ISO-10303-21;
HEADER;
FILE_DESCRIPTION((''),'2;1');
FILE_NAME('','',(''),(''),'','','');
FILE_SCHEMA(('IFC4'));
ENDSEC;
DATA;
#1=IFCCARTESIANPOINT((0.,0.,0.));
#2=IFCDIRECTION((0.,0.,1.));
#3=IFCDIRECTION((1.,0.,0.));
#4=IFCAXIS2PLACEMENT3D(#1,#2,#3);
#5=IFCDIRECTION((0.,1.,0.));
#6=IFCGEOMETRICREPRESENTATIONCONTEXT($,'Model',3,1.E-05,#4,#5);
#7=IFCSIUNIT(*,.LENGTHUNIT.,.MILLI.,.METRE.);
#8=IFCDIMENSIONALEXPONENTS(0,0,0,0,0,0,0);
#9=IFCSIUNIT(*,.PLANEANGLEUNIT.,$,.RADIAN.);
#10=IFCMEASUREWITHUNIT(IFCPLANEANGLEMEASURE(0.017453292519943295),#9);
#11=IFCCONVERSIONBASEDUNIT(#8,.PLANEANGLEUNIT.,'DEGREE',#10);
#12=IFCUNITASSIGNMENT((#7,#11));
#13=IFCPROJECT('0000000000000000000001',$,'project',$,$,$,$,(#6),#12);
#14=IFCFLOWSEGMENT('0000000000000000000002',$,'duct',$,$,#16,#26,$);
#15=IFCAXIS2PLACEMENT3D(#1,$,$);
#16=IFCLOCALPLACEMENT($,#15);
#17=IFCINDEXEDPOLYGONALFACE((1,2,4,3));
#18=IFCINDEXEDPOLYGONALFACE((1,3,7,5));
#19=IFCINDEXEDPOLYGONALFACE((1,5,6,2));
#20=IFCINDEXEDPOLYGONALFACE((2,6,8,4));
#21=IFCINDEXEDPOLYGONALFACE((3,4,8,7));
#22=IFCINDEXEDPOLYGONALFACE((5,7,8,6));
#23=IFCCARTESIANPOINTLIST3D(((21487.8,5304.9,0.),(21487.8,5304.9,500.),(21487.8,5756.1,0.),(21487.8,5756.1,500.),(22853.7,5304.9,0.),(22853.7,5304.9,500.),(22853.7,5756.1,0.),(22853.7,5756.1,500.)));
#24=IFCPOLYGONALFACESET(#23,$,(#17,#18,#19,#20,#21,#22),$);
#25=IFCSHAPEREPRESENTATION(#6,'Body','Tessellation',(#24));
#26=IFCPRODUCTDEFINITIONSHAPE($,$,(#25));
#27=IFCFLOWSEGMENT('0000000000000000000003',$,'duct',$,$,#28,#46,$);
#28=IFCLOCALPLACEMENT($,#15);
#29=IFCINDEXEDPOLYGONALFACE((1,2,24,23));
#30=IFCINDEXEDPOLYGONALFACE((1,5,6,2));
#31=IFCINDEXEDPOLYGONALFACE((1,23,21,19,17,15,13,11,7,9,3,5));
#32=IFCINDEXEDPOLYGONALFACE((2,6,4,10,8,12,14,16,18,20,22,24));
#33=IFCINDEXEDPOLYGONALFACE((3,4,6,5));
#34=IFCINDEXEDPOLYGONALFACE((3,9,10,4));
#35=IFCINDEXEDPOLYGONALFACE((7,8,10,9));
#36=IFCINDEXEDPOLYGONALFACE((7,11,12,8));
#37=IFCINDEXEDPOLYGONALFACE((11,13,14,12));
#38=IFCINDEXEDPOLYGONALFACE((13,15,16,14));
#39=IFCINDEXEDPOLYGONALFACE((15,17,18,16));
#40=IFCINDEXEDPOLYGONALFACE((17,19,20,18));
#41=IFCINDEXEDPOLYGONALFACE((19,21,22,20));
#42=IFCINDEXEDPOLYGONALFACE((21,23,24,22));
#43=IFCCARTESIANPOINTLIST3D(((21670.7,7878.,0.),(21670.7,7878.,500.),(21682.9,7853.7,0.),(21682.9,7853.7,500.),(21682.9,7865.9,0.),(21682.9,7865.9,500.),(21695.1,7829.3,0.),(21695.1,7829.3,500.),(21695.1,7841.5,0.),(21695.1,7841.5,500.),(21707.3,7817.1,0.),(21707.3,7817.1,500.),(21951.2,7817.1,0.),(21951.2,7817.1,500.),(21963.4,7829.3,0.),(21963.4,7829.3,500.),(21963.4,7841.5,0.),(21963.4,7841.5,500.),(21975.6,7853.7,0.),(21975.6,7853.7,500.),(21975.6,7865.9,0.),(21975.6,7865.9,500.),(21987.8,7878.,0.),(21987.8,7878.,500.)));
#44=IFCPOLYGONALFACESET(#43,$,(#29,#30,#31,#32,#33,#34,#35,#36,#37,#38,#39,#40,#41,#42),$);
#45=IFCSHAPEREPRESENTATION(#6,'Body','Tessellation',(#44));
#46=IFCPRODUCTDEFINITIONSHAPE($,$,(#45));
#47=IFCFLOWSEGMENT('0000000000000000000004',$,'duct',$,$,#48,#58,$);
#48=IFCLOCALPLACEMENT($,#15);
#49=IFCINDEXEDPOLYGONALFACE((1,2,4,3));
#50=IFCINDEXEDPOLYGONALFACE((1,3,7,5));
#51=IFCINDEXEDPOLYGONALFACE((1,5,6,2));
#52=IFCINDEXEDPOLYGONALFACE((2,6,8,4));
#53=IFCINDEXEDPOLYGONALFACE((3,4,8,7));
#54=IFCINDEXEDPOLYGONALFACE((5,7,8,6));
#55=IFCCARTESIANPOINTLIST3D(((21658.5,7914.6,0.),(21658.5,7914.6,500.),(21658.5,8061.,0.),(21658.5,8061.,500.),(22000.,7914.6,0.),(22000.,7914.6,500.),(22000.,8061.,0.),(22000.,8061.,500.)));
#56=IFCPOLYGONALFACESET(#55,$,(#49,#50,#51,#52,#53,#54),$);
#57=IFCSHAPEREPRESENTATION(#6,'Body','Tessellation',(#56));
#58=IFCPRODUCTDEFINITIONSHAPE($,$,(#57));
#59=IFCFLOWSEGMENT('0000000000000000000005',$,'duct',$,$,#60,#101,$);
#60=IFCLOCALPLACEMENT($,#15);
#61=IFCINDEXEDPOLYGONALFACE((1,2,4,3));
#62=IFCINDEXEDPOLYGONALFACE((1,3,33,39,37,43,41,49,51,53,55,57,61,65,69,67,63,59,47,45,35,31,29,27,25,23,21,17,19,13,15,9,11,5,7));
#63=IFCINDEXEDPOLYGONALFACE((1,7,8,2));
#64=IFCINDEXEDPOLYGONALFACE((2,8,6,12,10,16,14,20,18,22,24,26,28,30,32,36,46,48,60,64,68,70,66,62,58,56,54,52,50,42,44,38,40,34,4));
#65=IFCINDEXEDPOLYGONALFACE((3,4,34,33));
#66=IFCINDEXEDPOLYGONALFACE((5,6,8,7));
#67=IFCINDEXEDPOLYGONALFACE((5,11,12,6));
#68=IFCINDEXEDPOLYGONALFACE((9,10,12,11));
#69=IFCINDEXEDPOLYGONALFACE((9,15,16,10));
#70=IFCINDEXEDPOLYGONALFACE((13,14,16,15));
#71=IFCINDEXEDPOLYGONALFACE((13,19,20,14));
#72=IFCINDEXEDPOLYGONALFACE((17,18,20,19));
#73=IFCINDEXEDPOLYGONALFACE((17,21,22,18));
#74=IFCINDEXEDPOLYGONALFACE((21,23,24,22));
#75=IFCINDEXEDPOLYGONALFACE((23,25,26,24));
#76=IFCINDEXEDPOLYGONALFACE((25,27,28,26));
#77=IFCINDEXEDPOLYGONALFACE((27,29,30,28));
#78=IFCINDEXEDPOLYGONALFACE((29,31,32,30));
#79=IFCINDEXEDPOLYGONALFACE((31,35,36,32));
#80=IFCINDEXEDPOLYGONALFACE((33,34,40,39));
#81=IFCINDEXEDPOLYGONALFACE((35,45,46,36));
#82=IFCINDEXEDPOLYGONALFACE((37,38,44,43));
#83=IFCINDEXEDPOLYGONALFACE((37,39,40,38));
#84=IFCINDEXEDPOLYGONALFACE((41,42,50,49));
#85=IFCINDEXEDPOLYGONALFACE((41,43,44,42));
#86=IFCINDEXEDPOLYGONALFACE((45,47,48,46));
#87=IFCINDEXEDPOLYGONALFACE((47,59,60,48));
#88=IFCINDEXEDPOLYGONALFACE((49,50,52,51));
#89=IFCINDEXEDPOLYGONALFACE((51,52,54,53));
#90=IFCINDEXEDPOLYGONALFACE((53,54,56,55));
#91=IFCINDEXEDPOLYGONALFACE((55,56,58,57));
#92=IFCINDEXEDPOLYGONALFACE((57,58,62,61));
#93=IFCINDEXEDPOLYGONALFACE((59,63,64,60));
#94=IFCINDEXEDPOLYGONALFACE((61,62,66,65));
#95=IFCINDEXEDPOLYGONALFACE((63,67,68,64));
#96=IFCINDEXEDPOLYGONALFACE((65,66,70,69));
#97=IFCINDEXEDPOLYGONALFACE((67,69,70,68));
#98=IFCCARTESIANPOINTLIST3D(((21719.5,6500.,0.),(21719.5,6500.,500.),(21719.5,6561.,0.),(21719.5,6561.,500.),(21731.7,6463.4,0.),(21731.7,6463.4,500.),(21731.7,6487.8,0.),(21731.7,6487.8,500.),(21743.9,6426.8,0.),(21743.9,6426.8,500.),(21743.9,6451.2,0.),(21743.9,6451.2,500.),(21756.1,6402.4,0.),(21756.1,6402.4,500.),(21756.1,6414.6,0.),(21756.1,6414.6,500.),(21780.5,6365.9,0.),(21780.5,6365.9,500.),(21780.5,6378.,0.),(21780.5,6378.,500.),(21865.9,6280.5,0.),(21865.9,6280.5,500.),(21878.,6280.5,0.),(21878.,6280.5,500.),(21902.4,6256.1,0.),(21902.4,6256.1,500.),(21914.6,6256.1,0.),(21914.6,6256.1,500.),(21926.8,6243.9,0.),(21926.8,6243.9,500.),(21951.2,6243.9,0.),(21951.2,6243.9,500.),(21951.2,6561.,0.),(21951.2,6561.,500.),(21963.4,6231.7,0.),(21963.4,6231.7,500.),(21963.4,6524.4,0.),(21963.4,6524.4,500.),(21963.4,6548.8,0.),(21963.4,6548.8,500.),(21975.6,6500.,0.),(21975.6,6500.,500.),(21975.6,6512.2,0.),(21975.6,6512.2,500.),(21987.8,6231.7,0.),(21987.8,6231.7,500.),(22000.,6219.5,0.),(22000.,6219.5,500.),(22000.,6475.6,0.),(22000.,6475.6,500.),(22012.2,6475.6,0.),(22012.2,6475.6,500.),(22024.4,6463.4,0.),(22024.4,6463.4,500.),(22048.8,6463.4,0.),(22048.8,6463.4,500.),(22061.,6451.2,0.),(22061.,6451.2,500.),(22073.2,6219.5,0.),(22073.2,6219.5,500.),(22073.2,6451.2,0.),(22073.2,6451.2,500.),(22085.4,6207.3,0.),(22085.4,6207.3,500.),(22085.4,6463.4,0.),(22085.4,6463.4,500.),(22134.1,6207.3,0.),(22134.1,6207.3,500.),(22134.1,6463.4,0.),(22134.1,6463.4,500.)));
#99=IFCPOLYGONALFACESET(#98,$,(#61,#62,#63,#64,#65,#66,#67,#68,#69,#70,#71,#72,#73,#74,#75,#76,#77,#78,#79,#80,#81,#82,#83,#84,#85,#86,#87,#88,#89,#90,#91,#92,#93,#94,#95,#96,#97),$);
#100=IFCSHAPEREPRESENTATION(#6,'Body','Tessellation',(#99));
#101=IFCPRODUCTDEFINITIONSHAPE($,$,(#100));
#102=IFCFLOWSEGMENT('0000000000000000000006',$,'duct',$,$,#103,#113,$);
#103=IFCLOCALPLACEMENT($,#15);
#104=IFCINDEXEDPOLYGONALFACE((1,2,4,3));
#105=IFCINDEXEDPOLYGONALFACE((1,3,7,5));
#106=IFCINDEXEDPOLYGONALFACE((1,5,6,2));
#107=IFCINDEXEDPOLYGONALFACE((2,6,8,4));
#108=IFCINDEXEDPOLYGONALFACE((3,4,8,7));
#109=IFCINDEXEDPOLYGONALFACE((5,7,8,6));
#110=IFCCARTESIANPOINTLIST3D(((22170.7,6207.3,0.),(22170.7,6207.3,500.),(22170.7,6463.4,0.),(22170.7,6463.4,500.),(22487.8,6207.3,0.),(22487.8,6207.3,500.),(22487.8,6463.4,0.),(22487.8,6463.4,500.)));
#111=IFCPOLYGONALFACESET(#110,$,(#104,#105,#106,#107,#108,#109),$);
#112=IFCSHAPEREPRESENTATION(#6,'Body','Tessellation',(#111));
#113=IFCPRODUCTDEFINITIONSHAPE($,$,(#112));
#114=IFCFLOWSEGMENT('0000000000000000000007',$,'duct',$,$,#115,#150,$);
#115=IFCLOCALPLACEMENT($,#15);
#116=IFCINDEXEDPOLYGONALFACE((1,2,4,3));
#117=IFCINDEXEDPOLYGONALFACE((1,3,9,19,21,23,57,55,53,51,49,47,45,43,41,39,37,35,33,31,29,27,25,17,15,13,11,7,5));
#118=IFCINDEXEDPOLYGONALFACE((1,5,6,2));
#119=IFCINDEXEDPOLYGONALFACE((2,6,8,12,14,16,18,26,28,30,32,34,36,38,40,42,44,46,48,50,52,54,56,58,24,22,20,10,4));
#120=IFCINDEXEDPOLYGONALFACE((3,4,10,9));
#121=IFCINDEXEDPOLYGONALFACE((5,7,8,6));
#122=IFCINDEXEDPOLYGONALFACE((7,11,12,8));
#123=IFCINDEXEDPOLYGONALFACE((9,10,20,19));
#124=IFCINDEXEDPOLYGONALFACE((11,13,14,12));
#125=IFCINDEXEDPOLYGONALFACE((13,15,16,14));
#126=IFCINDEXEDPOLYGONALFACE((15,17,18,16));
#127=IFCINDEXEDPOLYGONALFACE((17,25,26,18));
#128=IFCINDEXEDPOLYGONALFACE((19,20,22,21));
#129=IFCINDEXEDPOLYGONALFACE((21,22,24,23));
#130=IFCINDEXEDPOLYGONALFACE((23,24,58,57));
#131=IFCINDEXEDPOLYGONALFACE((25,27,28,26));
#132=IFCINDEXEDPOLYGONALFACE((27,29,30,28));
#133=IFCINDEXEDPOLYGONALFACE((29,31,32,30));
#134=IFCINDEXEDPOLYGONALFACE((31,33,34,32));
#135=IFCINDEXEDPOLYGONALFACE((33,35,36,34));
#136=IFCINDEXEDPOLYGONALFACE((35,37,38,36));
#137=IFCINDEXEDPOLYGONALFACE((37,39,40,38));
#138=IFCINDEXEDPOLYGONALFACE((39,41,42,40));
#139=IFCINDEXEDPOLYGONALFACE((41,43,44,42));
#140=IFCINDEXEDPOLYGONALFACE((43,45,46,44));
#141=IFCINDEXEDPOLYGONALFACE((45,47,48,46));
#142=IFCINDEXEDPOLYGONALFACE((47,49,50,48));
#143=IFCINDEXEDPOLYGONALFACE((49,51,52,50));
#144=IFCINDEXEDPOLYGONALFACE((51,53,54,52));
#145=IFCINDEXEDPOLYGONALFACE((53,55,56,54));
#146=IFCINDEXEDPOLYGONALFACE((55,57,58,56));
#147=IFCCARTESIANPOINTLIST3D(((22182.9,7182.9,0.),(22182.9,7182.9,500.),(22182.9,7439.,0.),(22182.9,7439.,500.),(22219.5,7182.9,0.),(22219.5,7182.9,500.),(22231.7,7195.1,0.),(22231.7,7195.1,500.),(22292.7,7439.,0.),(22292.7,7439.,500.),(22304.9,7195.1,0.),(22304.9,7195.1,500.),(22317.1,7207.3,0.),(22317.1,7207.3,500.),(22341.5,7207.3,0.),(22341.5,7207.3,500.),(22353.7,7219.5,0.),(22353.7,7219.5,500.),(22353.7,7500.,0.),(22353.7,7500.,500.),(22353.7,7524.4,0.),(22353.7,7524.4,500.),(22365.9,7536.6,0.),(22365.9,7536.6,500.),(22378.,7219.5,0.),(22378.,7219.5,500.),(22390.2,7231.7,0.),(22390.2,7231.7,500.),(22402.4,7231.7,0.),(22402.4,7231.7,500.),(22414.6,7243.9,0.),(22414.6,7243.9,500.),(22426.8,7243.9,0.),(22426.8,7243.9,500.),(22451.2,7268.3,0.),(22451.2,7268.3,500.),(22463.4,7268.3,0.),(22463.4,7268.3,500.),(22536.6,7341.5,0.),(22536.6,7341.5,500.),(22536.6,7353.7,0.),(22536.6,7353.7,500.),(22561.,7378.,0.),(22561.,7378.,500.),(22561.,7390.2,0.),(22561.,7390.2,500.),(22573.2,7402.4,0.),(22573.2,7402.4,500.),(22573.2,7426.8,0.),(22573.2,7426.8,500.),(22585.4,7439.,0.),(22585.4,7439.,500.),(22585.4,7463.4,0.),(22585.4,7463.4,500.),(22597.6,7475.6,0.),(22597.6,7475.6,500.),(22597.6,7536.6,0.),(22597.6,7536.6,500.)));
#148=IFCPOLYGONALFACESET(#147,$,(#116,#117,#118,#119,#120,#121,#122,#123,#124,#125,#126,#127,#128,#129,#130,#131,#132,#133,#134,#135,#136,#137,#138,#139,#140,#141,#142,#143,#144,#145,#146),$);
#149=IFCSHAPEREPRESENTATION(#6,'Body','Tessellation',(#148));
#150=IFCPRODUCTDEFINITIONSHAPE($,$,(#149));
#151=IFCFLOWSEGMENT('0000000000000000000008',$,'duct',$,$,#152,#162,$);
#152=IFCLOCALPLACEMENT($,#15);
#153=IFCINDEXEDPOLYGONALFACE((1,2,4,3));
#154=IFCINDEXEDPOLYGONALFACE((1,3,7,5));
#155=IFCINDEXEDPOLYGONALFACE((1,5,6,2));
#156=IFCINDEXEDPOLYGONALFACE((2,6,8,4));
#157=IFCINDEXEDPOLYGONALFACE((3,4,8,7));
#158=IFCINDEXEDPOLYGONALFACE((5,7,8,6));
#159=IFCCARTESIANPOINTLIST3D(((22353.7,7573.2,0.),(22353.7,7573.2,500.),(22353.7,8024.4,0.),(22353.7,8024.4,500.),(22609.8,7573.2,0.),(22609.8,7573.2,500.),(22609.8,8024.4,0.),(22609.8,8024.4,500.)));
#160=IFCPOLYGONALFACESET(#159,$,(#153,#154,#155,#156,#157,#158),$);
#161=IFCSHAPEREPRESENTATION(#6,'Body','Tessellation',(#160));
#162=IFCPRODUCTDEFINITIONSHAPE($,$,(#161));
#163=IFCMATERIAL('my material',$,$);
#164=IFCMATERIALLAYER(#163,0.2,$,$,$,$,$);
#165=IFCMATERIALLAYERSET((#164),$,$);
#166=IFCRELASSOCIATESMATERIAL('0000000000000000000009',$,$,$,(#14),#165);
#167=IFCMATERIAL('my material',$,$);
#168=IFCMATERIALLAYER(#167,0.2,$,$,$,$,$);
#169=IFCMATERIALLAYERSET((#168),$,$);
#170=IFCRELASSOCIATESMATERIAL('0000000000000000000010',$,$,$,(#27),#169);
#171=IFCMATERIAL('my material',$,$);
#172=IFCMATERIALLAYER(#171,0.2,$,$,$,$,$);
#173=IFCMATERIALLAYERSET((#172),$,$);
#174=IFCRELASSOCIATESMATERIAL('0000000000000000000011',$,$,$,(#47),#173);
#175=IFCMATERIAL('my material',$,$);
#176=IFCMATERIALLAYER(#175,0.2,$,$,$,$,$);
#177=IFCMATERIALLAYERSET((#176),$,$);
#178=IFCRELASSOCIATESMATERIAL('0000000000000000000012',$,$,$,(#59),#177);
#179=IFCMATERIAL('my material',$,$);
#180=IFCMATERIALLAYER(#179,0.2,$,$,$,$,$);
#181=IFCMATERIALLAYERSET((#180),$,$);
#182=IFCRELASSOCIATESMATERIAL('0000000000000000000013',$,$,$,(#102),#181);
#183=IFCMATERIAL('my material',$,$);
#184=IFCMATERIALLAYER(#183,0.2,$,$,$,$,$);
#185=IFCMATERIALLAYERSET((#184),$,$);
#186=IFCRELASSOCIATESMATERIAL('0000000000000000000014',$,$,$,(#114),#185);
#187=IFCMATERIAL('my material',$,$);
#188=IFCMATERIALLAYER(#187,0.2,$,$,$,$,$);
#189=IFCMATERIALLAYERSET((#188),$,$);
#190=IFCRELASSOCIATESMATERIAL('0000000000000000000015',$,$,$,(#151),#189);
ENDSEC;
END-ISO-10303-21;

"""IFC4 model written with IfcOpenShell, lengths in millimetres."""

from ifc_helpers import new_model, entity, si_unit, converted_unit, direction, origin_with_axes, place, context, project, polyline, outline, extrude, material, layer, layer_set, layer_usage, element, save


model = new_model("IFC4")

# Units and contexts
model_context = context("Model", 3, precision=1e-05, world=origin_with_axes(), true_north=direction((0.0, 1.0, 0.0)))
ifc_project = project(units=[si_unit("LENGTHUNIT", "METRE", prefix="MILLI"), converted_unit("PLANEANGLEUNIT", "DEGREE", entity("IfcPlaneAngleMeasure", 0.017453292519943295), si_unit("PLANEANGLEUNIT", "RADIAN"), dimensions=[0, 0, 0, 0, 0, 0, 0])], contexts=[model_context])

# Flow segments
ifc_material_1 = material(Name="my material")
ifc_layer_1 = layer(ifc_material_1, 0.2)
ifc_layer_set_1 = layer_set([ifc_layer_1])
ifc_layer_usage_1 = layer_usage(ifc_layer_set_1, "AXIS2", "POSITIVE", -0.1)
flow_segment_1_placement = place(None, origin_with_axes())
element("IfcFlowSegment", 1, at=flow_segment_1_placement, material=ifc_layer_usage_1, Name="duct", context=model_context, shape_type="SweptSolid", body=[
    extrude(outline(polyline([(21487.8, 5304.9), (22853.7, 5304.9), (22853.7, 5756.1), (21487.8, 5756.1), (21487.8, 5304.9)])), origin_with_axes(), (0.0, 0.0, 1.0), 500.0),
])
ifc_material_2 = material(Name="my material")
ifc_layer_2 = layer(ifc_material_2, 0.2)
ifc_layer_set_2 = layer_set([ifc_layer_2])
ifc_layer_usage_2 = layer_usage(ifc_layer_set_2, "AXIS2", "POSITIVE", -0.1)
flow_segment_2_placement = place(None, origin_with_axes())
element("IfcFlowSegment", 2, at=flow_segment_2_placement, material=ifc_layer_usage_2, Name="duct", context=model_context, shape_type="SweptSolid", body=[
    extrude(outline(polyline([(21670.7, 7878.0), (21682.9, 7865.9), (21682.9, 7853.7), (21695.1, 7841.5), (21695.1, 7829.3), (21707.3, 7817.1), (21951.2, 7817.1), (21963.4, 7829.3), (21963.4, 7841.5), (21975.6, 7853.7), (21975.6, 7865.9), (21987.8, 7878.0), (21670.7, 7878.0)])), origin_with_axes(), (0.0, 0.0, 1.0), 500.0),
])
ifc_material_3 = material(Name="my material")
ifc_layer_3 = layer(ifc_material_3, 0.2)
ifc_layer_set_3 = layer_set([ifc_layer_3])
ifc_layer_usage_3 = layer_usage(ifc_layer_set_3, "AXIS2", "POSITIVE", -0.1)
flow_segment_3_placement = place(None, origin_with_axes())
element("IfcFlowSegment", 3, at=flow_segment_3_placement, material=ifc_layer_usage_3, Name="duct", context=model_context, shape_type="SweptSolid", body=[
    extrude(outline(polyline([(21658.5, 7914.6), (22000.0, 7914.6), (22000.0, 8061.0), (21658.5, 8061.0), (21658.5, 7914.6)])), origin_with_axes(), (0.0, 0.0, 1.0), 500.0),
])
ifc_material_4 = material(Name="my material")
ifc_layer_4 = layer(ifc_material_4, 0.2)
ifc_layer_set_4 = layer_set([ifc_layer_4])
ifc_layer_usage_4 = layer_usage(ifc_layer_set_4, "AXIS2", "POSITIVE", -0.1)
flow_segment_4_placement = place(None, origin_with_axes())
element("IfcFlowSegment", 4, at=flow_segment_4_placement, material=ifc_layer_usage_4, Name="duct", context=model_context, shape_type="SweptSolid", body=[
    extrude(outline(polyline([(21719.5, 6500.0), (21731.7, 6487.8), (21731.7, 6463.4), (21743.9, 6451.2), (21743.9, 6426.8), (21756.1, 6414.6), (21756.1, 6402.4), (21780.5, 6378.0), (21780.5, 6365.9), (21865.9, 6280.5), (21878.0, 6280.5), (21902.4, 6256.1), (21914.6, 6256.1), (21926.8, 6243.9), (21951.2, 6243.9), (21963.4, 6231.7), (21987.8, 6231.7), (22000.0, 6219.5), (22073.2, 6219.5), (22085.4, 6207.3), (22134.1, 6207.3), (22134.1, 6463.4), (22085.4, 6463.4), (22073.2, 6451.2), (22061.0, 6451.2), (22048.8, 6463.4), (22024.4, 6463.4), (22012.2, 6475.6), (22000.0, 6475.6), (21975.6, 6500.0), (21975.6, 6512.2), (21963.4, 6524.4), (21963.4, 6548.8), (21951.2, 6561.0), (21719.5, 6561.0), (21719.5, 6500.0)])), origin_with_axes(), (0.0, 0.0, 1.0), 500.0),
])
ifc_material_5 = material(Name="my material")
ifc_layer_5 = layer(ifc_material_5, 0.2)
ifc_layer_set_5 = layer_set([ifc_layer_5])
ifc_layer_usage_5 = layer_usage(ifc_layer_set_5, "AXIS2", "POSITIVE", -0.1)
flow_segment_5_placement = place(None, origin_with_axes())
element("IfcFlowSegment", 5, at=flow_segment_5_placement, material=ifc_layer_usage_5, Name="duct", context=model_context, shape_type="SweptSolid", body=[
    extrude(outline(polyline([(22170.7, 6207.3), (22487.8, 6207.3), (22487.8, 6463.4), (22170.7, 6463.4), (22170.7, 6207.3)])), origin_with_axes(), (0.0, 0.0, 1.0), 500.0),
])
ifc_material_6 = material(Name="my material")
ifc_layer_6 = layer(ifc_material_6, 0.2)
ifc_layer_set_6 = layer_set([ifc_layer_6])
ifc_layer_usage_6 = layer_usage(ifc_layer_set_6, "AXIS2", "POSITIVE", -0.1)
flow_segment_6_placement = place(None, origin_with_axes())
element("IfcFlowSegment", 6, at=flow_segment_6_placement, material=ifc_layer_usage_6, Name="duct", context=model_context, shape_type="SweptSolid", body=[
    extrude(outline(polyline([(22182.9, 7182.9), (22219.5, 7182.9), (22231.7, 7195.1), (22304.9, 7195.1), (22317.1, 7207.3), (22341.5, 7207.3), (22353.7, 7219.5), (22378.0, 7219.5), (22390.2, 7231.7), (22402.4, 7231.7), (22414.6, 7243.9), (22426.8, 7243.9), (22451.2, 7268.3), (22463.4, 7268.3), (22536.6, 7341.5), (22536.6, 7353.7), (22561.0, 7378.0), (22561.0, 7390.2), (22573.2, 7402.4), (22573.2, 7426.8), (22585.4, 7439.0), (22585.4, 7463.4), (22597.6, 7475.6), (22597.6, 7536.6), (22365.9, 7536.6), (22353.7, 7524.4), (22353.7, 7500.0), (22292.7, 7439.0), (22182.9, 7439.0), (22182.9, 7182.9)])), origin_with_axes(), (0.0, 0.0, 1.0), 500.0),
])
ifc_material_7 = material(Name="my material")
ifc_layer_7 = layer(ifc_material_7, 0.2)
ifc_layer_set_7 = layer_set([ifc_layer_7])
ifc_layer_usage_7 = layer_usage(ifc_layer_set_7, "AXIS2", "POSITIVE", -0.1)
flow_segment_7_placement = place(None, origin_with_axes())
element("IfcFlowSegment", 7, at=flow_segment_7_placement, material=ifc_layer_usage_7, Name="duct", context=model_context, shape_type="SweptSolid", body=[
    extrude(outline(polyline([(22353.7, 7573.2), (22609.8, 7573.2), (22609.8, 8024.4), (22353.7, 8024.4), (22353.7, 7573.2)])), origin_with_axes(), (0.0, 0.0, 1.0), 500.0),
])

save(model, "model.ifc")
